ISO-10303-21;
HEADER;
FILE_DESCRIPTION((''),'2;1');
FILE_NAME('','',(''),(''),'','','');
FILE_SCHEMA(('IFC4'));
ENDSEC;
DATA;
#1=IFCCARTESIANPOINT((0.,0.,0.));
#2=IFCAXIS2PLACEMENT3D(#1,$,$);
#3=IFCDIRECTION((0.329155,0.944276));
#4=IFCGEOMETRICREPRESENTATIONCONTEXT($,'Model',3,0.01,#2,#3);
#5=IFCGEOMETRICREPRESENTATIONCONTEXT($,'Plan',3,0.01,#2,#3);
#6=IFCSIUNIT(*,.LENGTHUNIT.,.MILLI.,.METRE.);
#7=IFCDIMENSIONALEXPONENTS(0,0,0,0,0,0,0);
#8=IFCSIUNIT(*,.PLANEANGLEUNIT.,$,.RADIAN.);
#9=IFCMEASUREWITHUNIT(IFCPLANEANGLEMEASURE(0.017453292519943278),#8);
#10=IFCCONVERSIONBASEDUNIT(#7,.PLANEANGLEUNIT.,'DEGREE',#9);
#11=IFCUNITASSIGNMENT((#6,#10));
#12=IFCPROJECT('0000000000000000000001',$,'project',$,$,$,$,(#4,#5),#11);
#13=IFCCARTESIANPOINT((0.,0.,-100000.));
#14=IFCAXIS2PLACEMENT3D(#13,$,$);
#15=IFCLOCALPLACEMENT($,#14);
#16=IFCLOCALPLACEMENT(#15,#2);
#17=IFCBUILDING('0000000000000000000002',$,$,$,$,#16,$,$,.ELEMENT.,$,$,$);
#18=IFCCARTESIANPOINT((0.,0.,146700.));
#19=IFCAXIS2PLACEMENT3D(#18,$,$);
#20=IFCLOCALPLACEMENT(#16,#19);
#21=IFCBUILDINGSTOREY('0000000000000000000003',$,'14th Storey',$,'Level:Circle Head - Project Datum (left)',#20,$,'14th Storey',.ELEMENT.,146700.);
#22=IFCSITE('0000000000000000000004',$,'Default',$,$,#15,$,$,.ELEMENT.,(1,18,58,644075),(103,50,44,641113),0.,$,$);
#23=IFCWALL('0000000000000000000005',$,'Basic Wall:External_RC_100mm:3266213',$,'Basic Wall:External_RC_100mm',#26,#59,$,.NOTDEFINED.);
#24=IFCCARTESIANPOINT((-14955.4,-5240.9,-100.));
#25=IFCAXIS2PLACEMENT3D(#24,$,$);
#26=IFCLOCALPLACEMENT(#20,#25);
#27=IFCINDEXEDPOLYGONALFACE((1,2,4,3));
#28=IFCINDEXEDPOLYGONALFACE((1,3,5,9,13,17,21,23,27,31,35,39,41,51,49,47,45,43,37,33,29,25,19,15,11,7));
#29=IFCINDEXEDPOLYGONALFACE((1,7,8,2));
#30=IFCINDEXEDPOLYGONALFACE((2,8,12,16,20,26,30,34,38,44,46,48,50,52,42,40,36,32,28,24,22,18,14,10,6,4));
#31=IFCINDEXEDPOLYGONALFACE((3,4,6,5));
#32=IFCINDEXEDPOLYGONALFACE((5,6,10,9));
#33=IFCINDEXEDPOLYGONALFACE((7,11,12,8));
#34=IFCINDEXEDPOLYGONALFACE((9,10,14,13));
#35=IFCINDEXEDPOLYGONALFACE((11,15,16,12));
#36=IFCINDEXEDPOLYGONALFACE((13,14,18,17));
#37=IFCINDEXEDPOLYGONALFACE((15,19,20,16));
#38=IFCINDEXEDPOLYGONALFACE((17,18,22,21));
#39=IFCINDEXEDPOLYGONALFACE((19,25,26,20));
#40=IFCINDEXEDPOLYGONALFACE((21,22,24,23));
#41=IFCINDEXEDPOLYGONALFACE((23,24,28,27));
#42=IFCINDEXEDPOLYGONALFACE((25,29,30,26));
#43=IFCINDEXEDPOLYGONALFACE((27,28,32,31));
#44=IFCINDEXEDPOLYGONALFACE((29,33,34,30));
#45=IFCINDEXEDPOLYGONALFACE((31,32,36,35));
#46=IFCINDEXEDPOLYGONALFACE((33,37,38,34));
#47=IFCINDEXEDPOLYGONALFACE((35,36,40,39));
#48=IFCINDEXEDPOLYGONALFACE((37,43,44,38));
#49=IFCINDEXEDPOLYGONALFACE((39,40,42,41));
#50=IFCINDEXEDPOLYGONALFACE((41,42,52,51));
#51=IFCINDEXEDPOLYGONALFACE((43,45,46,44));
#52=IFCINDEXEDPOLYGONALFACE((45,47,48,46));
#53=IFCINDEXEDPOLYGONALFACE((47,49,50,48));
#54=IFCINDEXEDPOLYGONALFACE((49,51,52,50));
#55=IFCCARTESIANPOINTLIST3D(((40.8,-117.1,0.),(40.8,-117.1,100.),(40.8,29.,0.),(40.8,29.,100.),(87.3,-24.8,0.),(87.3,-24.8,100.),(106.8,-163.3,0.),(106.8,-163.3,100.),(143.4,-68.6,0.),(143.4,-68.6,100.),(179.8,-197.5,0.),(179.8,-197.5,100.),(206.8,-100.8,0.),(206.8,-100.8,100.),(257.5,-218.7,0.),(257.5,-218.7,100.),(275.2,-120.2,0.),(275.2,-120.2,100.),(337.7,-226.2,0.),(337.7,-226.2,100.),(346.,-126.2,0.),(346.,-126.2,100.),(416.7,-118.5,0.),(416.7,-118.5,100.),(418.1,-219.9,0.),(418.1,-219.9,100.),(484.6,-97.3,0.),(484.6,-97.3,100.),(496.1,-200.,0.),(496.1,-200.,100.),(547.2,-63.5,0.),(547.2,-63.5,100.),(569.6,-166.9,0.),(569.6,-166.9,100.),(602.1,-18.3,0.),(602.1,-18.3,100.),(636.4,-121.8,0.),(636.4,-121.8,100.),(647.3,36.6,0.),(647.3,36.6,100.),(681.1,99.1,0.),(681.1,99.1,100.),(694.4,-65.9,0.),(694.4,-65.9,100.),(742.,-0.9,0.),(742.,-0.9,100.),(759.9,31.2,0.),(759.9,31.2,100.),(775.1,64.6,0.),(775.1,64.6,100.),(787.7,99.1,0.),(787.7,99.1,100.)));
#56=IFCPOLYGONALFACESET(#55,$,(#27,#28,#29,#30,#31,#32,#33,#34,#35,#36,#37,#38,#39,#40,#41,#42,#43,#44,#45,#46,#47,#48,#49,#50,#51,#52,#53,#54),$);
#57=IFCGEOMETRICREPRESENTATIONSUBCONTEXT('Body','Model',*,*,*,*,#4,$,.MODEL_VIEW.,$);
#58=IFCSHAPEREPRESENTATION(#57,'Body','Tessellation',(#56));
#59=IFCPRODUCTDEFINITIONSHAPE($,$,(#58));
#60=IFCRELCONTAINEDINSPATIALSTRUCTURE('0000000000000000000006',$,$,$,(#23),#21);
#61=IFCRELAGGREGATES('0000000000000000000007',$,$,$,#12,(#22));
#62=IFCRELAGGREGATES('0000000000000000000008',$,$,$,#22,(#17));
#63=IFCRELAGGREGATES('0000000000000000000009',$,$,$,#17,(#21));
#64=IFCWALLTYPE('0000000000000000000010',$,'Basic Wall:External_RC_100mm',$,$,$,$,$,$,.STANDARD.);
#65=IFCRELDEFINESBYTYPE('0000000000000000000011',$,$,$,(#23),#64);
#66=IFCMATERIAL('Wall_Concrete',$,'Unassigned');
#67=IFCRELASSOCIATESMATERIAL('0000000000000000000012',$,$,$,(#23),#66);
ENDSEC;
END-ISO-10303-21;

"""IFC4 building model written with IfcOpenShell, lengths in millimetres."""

from ifc_helpers import new_model, entity, si_unit, converted_unit, direction, frame, origin, place, context, subcontext, project, spatial, line, arc, indexed_curve, outline, extrude, material, type_object, element, save


model = new_model("IFC4")

# Units and contexts
model_context = context("Model", 3, precision=0.01, world=origin(), true_north=direction((0.329155, 0.944276)))
plan_context = context("Plan", 3, precision=0.01, world=origin(), true_north=direction((0.329155, 0.944276)))
body_context = subcontext(model_context, "Body", "Model", "MODEL_VIEW")
ifc_project = project(units=[si_unit("LENGTHUNIT", "METRE", prefix="MILLI"), converted_unit("PLANEANGLEUNIT", "DEGREE", entity("IfcPlaneAngleMeasure", 0.017453292519943278), si_unit("PLANEANGLEUNIT", "RADIAN"), dimensions=[0, 0, 0, 0, 0, 0, 0])], contexts=[model_context, plan_context])

# Site, building, storey
site_placement = place(None, frame((0.0, 0.0, -100000.0)))
site = spatial("IfcSite", under=ifc_project, at=site_placement, Name="Default", CompositionType="ELEMENT", RefLatitude=(1, 18, 58, 644075), RefLongitude=(103, 50, 44, 641113), RefElevation=0.0)
building_placement = place(site_placement, origin())
building = spatial("IfcBuilding", under=site, at=building_placement, CompositionType="ELEMENT")
storey_placement = place(building_placement, frame((0.0, 0.0, 146700.0)))
storey = spatial("IfcBuildingStorey", under=building, at=storey_placement, Name="14th Storey", ObjectType="Level:Circle Head - Project Datum (left)", LongName="14th Storey", CompositionType="ELEMENT", Elevation=146700.0)

# Wall
ifc_material_1 = material(Name="Wall_Concrete", Category="Unassigned")
wall_type_1 = type_object("IfcWallType", Name="Basic Wall:External_RC_100mm", PredefinedType="STANDARD")
wall_1_placement = place(storey_placement, frame((-14955.4, -5240.9, -100.0)))
element("IfcWall", 1, at=wall_1_placement, inside=storey, type_object=wall_type_1, material=ifc_material_1, Name="Basic Wall:External_RC_100mm:3266213", ObjectType="Basic Wall:External_RC_100mm", PredefinedType="NOTDEFINED", context=body_context, shape_type="SweptSolid", body=[
    extrude(outline(indexed_curve([(681.1, 99.1), (381.6, -124.0), (40.8, 29.0), (40.8, -117.1), (418.1, -219.9), (742.0, -0.9), (767.8, 47.8), (787.7, 99.1)], segments=[arc(1, 2, 3), line(3, 4), arc(4, 5, 6), arc(6, 7, 8), line(8, 1)], self_intersect=False)), origin(), (0.0, 0.0, 1.0), 100.0),
])

save(model, "model.ifc")
